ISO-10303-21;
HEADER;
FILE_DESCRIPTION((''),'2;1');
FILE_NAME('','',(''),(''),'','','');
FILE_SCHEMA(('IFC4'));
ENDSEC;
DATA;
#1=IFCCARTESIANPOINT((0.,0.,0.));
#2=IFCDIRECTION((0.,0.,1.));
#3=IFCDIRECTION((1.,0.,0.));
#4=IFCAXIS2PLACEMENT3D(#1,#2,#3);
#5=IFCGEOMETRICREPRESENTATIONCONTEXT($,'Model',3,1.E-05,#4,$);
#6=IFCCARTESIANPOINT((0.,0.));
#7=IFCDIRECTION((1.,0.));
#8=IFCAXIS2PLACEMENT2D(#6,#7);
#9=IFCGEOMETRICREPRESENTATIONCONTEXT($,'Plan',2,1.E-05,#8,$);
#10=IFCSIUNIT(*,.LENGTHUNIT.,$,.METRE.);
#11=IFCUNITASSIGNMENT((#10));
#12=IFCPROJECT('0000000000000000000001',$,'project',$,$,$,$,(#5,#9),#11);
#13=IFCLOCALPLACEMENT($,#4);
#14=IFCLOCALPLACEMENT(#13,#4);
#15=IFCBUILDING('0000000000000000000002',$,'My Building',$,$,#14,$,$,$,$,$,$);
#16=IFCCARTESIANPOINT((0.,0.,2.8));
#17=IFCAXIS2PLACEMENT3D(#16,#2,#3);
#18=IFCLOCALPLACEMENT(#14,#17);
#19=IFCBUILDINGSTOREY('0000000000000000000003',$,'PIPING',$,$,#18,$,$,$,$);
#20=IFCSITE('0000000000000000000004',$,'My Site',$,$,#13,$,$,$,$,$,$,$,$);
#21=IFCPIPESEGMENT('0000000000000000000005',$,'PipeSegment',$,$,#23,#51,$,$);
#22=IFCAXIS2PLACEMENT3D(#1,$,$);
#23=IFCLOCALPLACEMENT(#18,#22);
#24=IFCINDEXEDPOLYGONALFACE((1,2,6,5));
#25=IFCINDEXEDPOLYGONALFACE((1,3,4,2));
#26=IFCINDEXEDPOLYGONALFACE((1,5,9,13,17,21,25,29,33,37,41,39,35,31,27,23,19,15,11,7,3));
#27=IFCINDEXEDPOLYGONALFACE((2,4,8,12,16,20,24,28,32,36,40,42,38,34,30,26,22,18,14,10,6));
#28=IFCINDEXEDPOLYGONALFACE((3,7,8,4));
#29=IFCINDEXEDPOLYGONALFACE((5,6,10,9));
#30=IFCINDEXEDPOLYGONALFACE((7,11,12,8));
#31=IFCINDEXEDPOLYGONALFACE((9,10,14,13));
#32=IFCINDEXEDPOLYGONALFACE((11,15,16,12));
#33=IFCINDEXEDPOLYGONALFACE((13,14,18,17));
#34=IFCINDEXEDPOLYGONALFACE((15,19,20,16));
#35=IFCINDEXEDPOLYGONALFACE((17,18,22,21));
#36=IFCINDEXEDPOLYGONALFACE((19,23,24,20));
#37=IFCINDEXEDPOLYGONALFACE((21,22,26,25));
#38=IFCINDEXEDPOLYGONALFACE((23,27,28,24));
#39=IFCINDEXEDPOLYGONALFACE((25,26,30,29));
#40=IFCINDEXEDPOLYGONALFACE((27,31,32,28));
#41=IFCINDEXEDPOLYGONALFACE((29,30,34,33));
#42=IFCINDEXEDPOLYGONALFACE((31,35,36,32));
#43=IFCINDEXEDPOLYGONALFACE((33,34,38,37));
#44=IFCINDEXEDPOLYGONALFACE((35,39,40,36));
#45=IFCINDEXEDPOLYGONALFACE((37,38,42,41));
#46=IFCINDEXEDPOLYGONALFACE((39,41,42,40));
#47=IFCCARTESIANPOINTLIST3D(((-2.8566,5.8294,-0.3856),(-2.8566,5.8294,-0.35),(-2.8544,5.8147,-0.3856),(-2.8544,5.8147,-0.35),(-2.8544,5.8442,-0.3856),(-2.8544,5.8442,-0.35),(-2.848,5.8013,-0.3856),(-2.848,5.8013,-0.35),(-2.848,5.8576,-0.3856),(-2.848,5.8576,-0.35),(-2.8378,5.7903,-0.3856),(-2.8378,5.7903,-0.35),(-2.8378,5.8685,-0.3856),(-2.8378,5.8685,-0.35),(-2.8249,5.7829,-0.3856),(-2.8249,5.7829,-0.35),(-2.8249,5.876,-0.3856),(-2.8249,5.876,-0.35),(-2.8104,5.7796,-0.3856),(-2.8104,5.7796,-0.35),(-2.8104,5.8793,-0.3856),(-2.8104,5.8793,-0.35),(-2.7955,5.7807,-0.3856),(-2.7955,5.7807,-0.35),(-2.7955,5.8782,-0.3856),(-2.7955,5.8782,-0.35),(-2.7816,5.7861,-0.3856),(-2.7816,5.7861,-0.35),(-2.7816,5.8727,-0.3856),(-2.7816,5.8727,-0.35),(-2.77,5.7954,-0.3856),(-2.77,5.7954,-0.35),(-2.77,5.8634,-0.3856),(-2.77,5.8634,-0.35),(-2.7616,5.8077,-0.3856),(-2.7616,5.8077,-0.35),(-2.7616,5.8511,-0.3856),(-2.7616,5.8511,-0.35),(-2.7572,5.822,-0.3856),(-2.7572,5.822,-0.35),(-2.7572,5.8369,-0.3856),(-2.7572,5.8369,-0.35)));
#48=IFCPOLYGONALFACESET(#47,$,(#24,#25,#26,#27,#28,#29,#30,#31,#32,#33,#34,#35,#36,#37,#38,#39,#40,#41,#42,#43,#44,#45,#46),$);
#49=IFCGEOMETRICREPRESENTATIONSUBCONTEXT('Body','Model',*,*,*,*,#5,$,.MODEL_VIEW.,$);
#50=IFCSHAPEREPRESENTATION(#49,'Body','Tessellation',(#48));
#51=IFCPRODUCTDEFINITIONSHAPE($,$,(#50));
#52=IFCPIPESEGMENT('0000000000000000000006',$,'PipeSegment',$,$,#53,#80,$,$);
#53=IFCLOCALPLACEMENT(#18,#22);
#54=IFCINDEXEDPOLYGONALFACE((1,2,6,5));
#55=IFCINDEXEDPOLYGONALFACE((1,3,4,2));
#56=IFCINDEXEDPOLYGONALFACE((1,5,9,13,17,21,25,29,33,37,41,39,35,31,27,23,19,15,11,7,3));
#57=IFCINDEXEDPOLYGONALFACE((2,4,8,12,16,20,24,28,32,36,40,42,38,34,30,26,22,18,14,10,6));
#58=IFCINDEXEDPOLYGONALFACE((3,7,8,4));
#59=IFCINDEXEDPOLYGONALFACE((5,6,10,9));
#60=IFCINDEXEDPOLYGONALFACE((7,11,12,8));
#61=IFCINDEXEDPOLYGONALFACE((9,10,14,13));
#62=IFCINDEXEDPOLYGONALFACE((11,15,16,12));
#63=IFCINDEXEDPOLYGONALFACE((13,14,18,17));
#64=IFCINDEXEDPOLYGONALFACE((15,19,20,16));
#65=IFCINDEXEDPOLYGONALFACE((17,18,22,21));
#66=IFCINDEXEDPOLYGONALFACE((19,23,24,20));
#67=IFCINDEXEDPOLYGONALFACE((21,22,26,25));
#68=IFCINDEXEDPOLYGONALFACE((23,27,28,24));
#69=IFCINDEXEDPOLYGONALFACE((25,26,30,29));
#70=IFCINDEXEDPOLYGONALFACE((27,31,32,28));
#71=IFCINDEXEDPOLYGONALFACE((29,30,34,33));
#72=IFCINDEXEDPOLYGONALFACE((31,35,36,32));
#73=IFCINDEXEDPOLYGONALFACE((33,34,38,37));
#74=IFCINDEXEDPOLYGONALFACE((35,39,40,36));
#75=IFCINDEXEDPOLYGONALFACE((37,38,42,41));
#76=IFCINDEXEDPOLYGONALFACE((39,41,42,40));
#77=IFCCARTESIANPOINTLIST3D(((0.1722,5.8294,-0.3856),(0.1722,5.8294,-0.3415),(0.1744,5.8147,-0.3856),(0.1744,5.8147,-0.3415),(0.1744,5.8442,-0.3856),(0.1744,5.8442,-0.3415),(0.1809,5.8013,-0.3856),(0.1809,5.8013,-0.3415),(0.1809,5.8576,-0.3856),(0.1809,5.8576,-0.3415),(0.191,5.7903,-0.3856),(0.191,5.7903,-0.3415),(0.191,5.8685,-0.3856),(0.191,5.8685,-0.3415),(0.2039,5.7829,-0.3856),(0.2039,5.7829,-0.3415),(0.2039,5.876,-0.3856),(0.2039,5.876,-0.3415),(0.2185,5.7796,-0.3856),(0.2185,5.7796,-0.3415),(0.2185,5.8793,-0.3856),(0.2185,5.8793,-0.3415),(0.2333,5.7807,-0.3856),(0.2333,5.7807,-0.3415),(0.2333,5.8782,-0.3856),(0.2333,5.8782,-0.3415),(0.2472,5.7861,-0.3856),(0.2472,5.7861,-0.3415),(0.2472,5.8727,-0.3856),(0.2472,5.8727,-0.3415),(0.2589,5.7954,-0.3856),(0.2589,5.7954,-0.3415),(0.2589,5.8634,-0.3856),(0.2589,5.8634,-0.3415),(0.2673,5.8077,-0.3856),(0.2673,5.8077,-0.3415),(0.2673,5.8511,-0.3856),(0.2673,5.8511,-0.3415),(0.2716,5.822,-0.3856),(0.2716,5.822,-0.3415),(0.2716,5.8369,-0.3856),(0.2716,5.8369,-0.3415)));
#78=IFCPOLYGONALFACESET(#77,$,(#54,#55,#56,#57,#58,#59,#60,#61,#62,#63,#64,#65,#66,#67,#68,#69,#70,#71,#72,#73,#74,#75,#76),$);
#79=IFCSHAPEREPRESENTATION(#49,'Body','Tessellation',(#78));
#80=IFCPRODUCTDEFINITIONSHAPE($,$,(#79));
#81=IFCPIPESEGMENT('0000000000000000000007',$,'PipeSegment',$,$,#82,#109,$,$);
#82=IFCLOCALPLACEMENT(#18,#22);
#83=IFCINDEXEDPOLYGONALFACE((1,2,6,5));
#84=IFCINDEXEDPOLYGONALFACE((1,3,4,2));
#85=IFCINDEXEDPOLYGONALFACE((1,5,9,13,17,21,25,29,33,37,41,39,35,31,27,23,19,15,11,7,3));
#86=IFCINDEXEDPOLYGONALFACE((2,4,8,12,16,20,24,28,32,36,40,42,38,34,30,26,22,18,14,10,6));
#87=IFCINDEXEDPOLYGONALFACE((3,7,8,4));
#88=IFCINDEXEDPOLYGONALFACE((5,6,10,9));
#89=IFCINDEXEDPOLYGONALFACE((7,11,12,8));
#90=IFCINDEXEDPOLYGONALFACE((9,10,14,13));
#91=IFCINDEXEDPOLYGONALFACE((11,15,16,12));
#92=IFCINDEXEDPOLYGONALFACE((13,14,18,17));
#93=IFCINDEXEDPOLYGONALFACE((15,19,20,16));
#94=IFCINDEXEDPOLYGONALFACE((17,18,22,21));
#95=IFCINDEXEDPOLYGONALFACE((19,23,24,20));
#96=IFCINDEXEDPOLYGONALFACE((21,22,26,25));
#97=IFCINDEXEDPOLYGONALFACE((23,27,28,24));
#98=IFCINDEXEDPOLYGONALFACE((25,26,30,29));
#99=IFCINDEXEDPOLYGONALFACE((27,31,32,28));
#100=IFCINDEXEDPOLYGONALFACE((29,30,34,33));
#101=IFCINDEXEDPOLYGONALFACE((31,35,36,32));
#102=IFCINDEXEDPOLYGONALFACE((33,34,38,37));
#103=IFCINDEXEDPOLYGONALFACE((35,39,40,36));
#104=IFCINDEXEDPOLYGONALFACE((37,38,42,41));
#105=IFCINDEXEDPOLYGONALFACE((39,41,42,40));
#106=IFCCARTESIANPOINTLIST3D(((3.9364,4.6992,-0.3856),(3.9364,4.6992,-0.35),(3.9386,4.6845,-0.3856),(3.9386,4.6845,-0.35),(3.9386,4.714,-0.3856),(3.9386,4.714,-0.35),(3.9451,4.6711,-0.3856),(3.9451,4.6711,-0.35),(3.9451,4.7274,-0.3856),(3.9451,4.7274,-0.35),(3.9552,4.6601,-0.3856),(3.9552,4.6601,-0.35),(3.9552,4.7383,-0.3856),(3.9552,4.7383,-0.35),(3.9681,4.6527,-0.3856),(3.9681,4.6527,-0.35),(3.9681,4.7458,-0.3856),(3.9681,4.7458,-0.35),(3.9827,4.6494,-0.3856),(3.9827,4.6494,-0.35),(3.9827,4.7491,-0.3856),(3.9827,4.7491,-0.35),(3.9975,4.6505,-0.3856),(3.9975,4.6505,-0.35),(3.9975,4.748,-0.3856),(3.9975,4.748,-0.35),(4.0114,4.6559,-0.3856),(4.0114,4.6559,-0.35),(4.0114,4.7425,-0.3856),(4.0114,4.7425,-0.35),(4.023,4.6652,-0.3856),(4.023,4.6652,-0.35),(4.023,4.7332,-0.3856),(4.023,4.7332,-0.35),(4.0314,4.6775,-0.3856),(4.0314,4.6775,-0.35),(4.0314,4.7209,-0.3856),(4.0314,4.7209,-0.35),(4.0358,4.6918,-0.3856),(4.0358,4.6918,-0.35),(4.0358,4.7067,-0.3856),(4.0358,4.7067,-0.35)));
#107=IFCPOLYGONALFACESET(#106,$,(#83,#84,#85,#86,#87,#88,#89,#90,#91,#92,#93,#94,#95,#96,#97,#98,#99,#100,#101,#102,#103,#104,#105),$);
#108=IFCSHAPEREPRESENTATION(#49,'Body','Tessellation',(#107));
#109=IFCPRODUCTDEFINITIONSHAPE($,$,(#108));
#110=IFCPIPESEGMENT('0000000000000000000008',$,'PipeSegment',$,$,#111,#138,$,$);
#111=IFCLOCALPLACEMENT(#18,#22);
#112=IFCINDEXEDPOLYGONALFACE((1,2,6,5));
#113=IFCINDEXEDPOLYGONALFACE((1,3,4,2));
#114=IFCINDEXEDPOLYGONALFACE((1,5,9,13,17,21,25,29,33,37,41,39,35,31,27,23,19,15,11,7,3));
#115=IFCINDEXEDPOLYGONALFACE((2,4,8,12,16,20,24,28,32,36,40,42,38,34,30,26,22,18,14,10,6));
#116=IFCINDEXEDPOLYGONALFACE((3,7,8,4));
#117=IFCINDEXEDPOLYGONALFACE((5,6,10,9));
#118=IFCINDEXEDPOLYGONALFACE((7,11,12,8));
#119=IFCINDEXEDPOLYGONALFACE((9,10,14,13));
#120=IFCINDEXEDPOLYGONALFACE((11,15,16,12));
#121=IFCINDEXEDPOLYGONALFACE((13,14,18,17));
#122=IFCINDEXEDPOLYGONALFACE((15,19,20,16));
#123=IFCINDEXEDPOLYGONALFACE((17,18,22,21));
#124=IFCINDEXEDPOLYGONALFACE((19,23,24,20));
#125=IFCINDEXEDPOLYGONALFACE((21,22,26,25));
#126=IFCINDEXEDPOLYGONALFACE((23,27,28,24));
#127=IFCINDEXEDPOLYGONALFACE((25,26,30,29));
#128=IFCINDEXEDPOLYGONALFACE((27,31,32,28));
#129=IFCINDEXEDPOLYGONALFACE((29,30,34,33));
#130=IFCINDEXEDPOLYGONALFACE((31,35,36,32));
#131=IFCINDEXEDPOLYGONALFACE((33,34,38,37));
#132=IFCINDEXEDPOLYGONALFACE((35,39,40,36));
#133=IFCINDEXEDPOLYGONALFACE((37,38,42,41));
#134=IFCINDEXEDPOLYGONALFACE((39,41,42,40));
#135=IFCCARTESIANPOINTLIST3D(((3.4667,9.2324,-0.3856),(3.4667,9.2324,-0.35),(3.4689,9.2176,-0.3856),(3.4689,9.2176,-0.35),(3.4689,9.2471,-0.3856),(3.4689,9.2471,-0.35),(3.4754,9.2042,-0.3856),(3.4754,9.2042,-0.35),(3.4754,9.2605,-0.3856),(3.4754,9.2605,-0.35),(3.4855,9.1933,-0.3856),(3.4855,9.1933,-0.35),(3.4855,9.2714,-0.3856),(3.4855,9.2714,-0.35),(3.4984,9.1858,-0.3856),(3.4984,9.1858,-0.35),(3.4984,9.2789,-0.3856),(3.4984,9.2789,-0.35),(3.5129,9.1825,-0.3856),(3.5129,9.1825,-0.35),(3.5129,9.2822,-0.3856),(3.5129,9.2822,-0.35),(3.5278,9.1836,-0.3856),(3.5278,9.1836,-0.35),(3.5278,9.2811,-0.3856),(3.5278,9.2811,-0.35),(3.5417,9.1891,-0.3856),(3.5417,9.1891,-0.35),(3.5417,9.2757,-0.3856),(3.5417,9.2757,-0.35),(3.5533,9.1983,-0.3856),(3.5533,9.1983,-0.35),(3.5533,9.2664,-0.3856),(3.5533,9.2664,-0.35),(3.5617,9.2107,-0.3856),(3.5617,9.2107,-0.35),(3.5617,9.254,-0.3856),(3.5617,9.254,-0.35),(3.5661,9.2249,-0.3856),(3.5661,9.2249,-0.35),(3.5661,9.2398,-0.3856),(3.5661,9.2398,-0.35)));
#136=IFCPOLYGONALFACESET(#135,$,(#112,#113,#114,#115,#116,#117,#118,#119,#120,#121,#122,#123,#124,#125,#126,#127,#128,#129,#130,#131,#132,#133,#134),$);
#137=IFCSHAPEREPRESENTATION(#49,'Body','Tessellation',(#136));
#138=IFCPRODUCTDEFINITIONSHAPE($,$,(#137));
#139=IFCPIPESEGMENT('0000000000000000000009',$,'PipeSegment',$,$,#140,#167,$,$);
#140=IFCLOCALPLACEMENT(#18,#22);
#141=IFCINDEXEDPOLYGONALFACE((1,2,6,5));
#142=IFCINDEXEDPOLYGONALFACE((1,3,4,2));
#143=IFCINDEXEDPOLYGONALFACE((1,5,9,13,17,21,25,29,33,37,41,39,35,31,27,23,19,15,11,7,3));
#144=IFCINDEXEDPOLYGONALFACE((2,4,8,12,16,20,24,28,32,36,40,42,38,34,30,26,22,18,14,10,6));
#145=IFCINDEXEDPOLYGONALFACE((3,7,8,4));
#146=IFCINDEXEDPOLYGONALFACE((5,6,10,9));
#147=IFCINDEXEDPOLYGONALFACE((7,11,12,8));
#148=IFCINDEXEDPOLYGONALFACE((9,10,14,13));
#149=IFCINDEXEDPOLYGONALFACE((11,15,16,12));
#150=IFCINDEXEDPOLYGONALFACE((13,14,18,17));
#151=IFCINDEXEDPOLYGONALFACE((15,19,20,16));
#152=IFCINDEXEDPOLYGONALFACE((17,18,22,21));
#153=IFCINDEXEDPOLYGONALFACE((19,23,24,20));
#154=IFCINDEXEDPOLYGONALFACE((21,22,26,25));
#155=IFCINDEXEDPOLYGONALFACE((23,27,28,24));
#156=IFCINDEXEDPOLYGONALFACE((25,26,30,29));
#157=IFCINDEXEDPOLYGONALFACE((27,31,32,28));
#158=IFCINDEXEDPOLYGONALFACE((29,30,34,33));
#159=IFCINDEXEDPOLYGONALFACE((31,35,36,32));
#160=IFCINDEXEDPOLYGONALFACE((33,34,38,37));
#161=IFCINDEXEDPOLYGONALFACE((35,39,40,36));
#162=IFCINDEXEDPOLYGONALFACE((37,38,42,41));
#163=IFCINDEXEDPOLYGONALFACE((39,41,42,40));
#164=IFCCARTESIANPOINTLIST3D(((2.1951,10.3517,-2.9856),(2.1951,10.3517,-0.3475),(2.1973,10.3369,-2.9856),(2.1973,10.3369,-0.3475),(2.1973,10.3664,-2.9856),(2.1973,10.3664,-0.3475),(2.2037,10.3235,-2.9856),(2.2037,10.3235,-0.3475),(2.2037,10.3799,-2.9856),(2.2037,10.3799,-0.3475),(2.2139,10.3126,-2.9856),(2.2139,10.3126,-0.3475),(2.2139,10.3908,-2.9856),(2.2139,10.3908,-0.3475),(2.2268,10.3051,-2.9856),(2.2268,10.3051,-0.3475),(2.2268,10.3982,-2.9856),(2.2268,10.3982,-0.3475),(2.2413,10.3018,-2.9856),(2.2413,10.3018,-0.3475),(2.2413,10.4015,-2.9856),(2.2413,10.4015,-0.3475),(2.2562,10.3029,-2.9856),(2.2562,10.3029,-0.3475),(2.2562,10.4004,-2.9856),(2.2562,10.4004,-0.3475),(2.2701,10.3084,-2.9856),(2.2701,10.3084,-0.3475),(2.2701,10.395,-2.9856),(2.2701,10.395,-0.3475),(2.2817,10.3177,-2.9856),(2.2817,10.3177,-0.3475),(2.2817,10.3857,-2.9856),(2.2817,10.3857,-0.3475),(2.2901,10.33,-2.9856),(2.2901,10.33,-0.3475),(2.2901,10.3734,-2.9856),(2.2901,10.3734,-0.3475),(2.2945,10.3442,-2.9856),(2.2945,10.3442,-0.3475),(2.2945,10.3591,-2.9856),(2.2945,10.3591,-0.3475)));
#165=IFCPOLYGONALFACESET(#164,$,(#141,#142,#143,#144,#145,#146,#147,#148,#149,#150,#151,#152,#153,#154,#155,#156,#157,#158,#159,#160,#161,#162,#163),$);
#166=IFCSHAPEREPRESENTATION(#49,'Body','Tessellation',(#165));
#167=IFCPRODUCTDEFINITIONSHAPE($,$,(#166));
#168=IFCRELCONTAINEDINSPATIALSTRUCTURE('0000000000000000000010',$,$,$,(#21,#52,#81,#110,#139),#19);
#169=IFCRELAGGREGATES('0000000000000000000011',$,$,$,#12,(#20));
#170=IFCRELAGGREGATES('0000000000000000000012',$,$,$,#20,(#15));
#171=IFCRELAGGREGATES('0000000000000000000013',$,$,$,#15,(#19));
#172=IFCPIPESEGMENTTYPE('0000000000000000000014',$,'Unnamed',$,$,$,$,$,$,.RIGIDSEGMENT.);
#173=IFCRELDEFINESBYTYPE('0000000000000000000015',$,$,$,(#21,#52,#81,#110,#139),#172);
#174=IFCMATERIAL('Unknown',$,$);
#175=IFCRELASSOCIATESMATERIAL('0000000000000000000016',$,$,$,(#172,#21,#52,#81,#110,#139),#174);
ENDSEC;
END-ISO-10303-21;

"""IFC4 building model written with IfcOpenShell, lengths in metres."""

from ifc_helpers import new_model, si_unit, frame, origin_with_axes, origin_2d_with_axis, place, context, subcontext, project, spatial, circle, extrude, material, material_profile, profile_set, profile_usage, type_object, element, save


model = new_model("IFC4")

# Units and contexts
model_context = context("Model", 3, precision=1e-05, world=origin_with_axes())
plan_context = context("Plan", 2, precision=1e-05, world=origin_2d_with_axis())
body_context = subcontext(model_context, "Body", "Model", "MODEL_VIEW")
ifc_project = project(units=[si_unit("LENGTHUNIT", "METRE")], contexts=[model_context, plan_context])

# Site, building, storey
site_placement = place(None, origin_with_axes())
site = spatial("IfcSite", under=ifc_project, at=site_placement, Name="My Site")
building_placement = place(site_placement, origin_with_axes())
building = spatial("IfcBuilding", under=site, at=building_placement, Name="My Building")
storey_placement = place(building_placement, frame((0.0, 0.0, 2.8), z_axis=(0.0, 0.0, 1.0), x_axis=(1.0, 0.0, 0.0)))
storey = spatial("IfcBuildingStorey", under=building, at=storey_placement, Name="PIPING")

# Pipe segments
ifc_material = material(Name="Unknown")
ifc_material_profile = material_profile(ifc_material, circle(Radius=0.05))
ifc_profile_set = profile_set([ifc_material_profile])
pipe_segment_type = type_object("IfcPipeSegmentType", Name="Unnamed", PredefinedType="RIGIDSEGMENT", material=ifc_profile_set)
ifc_profile_usage_1 = profile_usage(ifc_profile_set, cardinal=5)
pipe_segment_1_placement = place(storey_placement, frame((-2.8066, 5.8294, -0.35), z_axis=(0.0, 0.0, -1.0), x_axis=(-1.0, 0.0, 0.0)))
element("IfcPipeSegment", 1, at=pipe_segment_1_placement, inside=storey, type_object=pipe_segment_type, material=ifc_profile_usage_1, Name="PipeSegment", context=body_context, shape_type="SweptSolid", body=[
    extrude(circle(Radius=0.05), origin_with_axes(), (0.0, 0.0, 1.0), 0.0356),
])
ifc_profile_usage_2 = profile_usage(ifc_profile_set, cardinal=5)
pipe_segment_2_placement = place(storey_placement, frame((0.2222, 5.8294, -0.3415), z_axis=(0.0, 0.0, -1.0), x_axis=(-1.0, 0.0, 0.0)))
element("IfcPipeSegment", 2, at=pipe_segment_2_placement, inside=storey, type_object=pipe_segment_type, material=ifc_profile_usage_2, Name="PipeSegment", context=body_context, shape_type="SweptSolid", body=[
    extrude(circle(Radius=0.05), origin_with_axes(), (0.0, 0.0, 1.0), 0.044),
])
ifc_profile_usage_3 = profile_usage(ifc_profile_set, cardinal=5)
pipe_segment_3_placement = place(storey_placement, frame((3.9864, 4.6992, -0.35), z_axis=(0.0, 0.0, -1.0), x_axis=(-1.0, 0.0, 0.0)))
element("IfcPipeSegment", 3, at=pipe_segment_3_placement, inside=storey, type_object=pipe_segment_type, material=ifc_profile_usage_3, Name="PipeSegment", context=body_context, shape_type="SweptSolid", body=[
    extrude(circle(Radius=0.05), origin_with_axes(), (0.0, 0.0, 1.0), 0.0356),
])
ifc_profile_usage_4 = profile_usage(ifc_profile_set, cardinal=5)
pipe_segment_4_placement = place(storey_placement, frame((3.5167, 9.2324, -0.35), z_axis=(0.0, 0.0, -1.0), x_axis=(-1.0, 0.0, 0.0)))
element("IfcPipeSegment", 4, at=pipe_segment_4_placement, inside=storey, type_object=pipe_segment_type, material=ifc_profile_usage_4, Name="PipeSegment", context=body_context, shape_type="SweptSolid", body=[
    extrude(circle(Radius=0.05), origin_with_axes(), (0.0, 0.0, 1.0), 0.0356),
])
ifc_profile_usage_5 = profile_usage(ifc_profile_set, cardinal=5)
pipe_segment_5_placement = place(storey_placement, frame((2.2451, 10.3517, -0.3475), z_axis=(0.0, 0.0, -1.0), x_axis=(-1.0, 0.0, 0.0)))
element("IfcPipeSegment", 5, at=pipe_segment_5_placement, inside=storey, type_object=pipe_segment_type, material=ifc_profile_usage_5, Name="PipeSegment", context=body_context, shape_type="SweptSolid", body=[
    extrude(circle(Radius=0.05), origin_with_axes(), (0.0, 0.0, 1.0), 2.6381),
])

save(model, "model.ifc")
